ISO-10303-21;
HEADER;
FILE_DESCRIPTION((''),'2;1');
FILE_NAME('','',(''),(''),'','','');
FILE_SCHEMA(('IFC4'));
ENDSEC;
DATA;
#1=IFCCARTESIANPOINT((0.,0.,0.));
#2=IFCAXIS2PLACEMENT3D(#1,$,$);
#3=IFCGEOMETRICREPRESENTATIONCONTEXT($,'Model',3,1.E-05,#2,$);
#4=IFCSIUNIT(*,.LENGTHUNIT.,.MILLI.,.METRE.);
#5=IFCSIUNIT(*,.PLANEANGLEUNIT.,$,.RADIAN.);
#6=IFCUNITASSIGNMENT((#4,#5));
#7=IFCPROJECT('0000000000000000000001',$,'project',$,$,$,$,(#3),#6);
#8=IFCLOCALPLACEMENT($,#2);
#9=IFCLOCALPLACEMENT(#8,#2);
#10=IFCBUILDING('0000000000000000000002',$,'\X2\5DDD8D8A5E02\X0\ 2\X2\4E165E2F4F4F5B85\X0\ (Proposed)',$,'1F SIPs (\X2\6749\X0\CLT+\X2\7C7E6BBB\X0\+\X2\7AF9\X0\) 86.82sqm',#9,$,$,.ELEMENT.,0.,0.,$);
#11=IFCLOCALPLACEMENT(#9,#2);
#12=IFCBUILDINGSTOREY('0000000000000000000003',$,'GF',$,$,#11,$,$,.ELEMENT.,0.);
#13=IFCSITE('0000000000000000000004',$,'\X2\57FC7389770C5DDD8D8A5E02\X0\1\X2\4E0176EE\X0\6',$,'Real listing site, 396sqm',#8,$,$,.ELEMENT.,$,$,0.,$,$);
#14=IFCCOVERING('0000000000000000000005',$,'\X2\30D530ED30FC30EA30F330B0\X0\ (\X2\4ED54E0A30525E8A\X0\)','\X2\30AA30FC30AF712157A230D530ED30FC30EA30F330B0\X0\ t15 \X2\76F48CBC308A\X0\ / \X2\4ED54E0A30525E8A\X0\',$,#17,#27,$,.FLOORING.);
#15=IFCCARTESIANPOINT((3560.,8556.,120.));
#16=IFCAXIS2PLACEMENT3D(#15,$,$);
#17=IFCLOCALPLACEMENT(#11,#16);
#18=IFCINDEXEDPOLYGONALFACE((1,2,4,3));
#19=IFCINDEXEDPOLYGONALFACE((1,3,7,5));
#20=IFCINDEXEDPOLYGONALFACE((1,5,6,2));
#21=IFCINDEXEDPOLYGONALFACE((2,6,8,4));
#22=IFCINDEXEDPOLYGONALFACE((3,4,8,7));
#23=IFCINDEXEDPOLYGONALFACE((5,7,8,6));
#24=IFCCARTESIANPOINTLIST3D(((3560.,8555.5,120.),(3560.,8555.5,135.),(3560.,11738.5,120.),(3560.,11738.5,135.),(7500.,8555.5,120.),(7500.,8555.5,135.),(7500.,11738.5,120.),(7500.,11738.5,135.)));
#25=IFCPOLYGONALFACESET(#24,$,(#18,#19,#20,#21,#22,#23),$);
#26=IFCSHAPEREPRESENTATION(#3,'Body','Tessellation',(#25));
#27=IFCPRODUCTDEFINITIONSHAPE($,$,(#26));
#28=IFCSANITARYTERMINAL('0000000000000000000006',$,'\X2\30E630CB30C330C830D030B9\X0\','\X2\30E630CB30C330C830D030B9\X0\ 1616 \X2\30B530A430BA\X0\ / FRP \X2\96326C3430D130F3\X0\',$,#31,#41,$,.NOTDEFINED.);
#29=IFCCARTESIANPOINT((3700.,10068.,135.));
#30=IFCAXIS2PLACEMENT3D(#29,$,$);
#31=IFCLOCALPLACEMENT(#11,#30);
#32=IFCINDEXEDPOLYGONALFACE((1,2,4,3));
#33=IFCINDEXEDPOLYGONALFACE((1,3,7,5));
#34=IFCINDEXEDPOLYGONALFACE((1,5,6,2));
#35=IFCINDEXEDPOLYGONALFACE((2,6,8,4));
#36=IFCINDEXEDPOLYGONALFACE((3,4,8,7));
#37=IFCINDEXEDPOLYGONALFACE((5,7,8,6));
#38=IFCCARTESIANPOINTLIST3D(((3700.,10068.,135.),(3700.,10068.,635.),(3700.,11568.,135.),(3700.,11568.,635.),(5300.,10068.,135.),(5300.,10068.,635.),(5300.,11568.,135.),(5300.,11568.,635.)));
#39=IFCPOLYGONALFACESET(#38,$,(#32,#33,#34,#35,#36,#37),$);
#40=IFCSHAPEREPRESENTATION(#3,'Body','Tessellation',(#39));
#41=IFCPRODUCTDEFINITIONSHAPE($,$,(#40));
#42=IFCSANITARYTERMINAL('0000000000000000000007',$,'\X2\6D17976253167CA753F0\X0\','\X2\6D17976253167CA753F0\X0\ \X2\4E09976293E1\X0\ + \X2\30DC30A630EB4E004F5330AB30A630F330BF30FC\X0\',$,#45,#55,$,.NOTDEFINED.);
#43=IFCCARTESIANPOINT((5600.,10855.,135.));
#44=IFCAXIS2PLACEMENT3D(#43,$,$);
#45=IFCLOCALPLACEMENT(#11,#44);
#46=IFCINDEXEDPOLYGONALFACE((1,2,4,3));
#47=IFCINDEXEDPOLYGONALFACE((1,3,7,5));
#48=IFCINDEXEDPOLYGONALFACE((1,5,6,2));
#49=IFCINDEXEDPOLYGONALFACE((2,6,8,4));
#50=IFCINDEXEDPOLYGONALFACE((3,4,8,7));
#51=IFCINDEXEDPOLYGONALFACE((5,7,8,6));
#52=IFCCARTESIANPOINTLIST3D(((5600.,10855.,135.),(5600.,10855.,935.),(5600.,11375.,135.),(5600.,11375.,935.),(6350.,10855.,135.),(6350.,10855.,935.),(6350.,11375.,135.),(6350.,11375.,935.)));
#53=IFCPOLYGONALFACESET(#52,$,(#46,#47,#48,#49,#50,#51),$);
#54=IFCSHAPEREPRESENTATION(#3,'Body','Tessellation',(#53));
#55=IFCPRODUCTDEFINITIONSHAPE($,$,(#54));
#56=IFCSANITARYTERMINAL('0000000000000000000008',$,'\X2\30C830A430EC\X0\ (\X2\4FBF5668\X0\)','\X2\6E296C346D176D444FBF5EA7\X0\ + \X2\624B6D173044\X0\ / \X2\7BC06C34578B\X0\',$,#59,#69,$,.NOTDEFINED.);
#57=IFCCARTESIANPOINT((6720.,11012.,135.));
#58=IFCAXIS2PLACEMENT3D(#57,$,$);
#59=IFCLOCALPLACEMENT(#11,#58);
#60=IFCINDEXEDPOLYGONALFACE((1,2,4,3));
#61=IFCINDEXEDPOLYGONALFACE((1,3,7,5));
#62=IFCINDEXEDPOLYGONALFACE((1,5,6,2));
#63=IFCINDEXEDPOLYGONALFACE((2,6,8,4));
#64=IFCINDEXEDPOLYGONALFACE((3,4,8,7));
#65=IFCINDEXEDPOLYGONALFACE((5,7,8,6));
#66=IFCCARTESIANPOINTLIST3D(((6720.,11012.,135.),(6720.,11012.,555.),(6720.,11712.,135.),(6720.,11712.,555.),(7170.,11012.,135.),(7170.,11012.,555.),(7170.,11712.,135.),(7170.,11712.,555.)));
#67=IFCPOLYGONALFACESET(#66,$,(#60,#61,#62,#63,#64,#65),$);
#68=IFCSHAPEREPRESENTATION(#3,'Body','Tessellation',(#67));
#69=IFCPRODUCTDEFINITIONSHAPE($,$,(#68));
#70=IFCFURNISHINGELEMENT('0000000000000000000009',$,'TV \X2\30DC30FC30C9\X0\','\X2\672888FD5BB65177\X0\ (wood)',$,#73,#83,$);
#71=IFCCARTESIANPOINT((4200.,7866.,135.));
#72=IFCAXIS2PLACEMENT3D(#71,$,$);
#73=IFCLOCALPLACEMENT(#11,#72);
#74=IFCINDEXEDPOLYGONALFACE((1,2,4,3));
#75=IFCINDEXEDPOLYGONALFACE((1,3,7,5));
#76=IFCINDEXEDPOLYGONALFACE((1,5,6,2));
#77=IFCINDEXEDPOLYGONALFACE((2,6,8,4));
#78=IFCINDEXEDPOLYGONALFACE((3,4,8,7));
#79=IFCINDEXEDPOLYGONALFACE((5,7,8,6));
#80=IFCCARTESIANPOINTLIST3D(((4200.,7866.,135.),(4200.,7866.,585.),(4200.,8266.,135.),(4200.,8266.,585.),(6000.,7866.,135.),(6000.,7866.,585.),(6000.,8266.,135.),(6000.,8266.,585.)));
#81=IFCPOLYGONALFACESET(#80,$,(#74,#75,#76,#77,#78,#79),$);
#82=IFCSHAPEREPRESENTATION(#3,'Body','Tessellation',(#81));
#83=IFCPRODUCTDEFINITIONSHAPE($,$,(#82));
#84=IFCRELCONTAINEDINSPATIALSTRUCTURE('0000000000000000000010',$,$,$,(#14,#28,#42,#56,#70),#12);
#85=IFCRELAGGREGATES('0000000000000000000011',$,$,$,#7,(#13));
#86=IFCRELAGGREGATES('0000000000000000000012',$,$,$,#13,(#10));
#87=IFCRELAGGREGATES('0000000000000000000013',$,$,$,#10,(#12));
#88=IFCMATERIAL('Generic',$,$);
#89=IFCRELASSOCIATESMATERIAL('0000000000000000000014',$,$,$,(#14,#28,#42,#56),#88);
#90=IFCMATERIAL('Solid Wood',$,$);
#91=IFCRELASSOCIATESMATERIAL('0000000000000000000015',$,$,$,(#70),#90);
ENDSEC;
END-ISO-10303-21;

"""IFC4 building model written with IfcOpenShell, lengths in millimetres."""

from ifc_helpers import new_model, si_unit, frame, frame_2d, origin, place, context, project, spatial, rectangle, extrude, material, element, save


model = new_model("IFC4")

# Units and contexts
model_context = context("Model", 3, precision=1e-05, world=origin())
ifc_project = project(units=[si_unit("LENGTHUNIT", "METRE", prefix="MILLI"), si_unit("PLANEANGLEUNIT", "RADIAN")], contexts=[model_context])

# Site, building, storey
site_placement = place(None, origin())
site = spatial("IfcSite", under=ifc_project, at=site_placement, Name="埼玉県川越市1丁目6", ObjectType="Real listing site, 396sqm", CompositionType="ELEMENT", RefElevation=0.0)
building_placement = place(site_placement, origin())
building = spatial("IfcBuilding", under=site, at=building_placement, Name="川越市 2世帯住宅 (Proposed)", ObjectType="1F SIPs (杉CLT+籾殻+竹) 86.82sqm", CompositionType="ELEMENT", ElevationOfRefHeight=0.0, ElevationOfTerrain=0.0)
storey_placement = place(building_placement, origin())
storey = spatial("IfcBuildingStorey", under=building, at=storey_placement, Name="GF", CompositionType="ELEMENT", Elevation=0.0)

# Shared definitions
ifc_material_1 = material(Name="Solid Wood")
ifc_material_2 = material(Name="Generic")

# Covering
covering_placement = place(storey_placement, frame((3560.0, 8556.0, 120.0)))
element("IfcCovering", 1, at=covering_placement, inside=storey, material=ifc_material_2, Name="フローリング (仕上げ床)", Description="オーク無垢フローリング t15 直貼り / 仕上げ床", PredefinedType="FLOORING", context=model_context, shape_type="SweptSolid", body=[
    extrude(rectangle(XDim=3940.0, YDim=3183.0, at=frame_2d((1970.0, 1591.0))), frame((3560.0, 8556.0, 120.0)), (0.0, 0.0, 1.0), 15.0),
])

# Sanitary terminals
sanitary_terminal_1_placement = place(storey_placement, frame((3700.0, 10068.0, 135.0)))
element("IfcSanitaryTerminal", 2, at=sanitary_terminal_1_placement, inside=storey, material=ifc_material_2, Name="ユニットバス", Description="ユニットバス 1616 サイズ / FRP 防水パン", PredefinedType="NOTDEFINED", context=model_context, shape_type="SweptSolid", body=[
    extrude(rectangle(XDim=1600.0, YDim=1500.0, at=frame_2d((800.0, 750.0))), frame((3700.0, 10068.0, 135.0)), (0.0, 0.0, 1.0), 500.0),
])
sanitary_terminal_2_placement = place(storey_placement, frame((5600.0, 10855.0, 135.0)))
element("IfcSanitaryTerminal", 3, at=sanitary_terminal_2_placement, inside=storey, material=ifc_material_2, Name="洗面化粧台", Description="洗面化粧台 三面鏡 + ボウル一体カウンター", PredefinedType="NOTDEFINED", context=model_context, shape_type="SweptSolid", body=[
    extrude(rectangle(XDim=750.0, YDim=520.0, at=frame_2d((375.0, 260.0))), frame((5600.0, 10855.0, 135.0)), (0.0, 0.0, 1.0), 800.0),
])
sanitary_terminal_3_placement = place(storey_placement, frame((6720.0, 11012.0, 135.0)))
element("IfcSanitaryTerminal", 4, at=sanitary_terminal_3_placement, inside=storey, material=ifc_material_2, Name="トイレ (便器)", Description="温水洗浄便座 + 手洗い / 節水型", PredefinedType="NOTDEFINED", context=model_context, shape_type="SweptSolid", body=[
    extrude(rectangle(XDim=450.0, YDim=700.0, at=frame_2d((225.0, 350.0))), frame((6720.0, 11012.0, 135.0)), (0.0, 0.0, 1.0), 420.0),
])

# Furnishing element
furnishing_placement = place(storey_placement, frame((4200.0, 7866.0, 135.0)))
element("IfcFurnishingElement", 5, at=furnishing_placement, inside=storey, material=ifc_material_1, Name="TV ボード", Description="木製家具 (wood)", context=model_context, shape_type="SweptSolid", body=[
    extrude(rectangle(XDim=1800.0, YDim=400.0, at=frame_2d((900.0, 200.0))), frame((4200.0, 7866.0, 135.0)), (0.0, 0.0, 1.0), 450.0),
])

save(model, "model.ifc")
